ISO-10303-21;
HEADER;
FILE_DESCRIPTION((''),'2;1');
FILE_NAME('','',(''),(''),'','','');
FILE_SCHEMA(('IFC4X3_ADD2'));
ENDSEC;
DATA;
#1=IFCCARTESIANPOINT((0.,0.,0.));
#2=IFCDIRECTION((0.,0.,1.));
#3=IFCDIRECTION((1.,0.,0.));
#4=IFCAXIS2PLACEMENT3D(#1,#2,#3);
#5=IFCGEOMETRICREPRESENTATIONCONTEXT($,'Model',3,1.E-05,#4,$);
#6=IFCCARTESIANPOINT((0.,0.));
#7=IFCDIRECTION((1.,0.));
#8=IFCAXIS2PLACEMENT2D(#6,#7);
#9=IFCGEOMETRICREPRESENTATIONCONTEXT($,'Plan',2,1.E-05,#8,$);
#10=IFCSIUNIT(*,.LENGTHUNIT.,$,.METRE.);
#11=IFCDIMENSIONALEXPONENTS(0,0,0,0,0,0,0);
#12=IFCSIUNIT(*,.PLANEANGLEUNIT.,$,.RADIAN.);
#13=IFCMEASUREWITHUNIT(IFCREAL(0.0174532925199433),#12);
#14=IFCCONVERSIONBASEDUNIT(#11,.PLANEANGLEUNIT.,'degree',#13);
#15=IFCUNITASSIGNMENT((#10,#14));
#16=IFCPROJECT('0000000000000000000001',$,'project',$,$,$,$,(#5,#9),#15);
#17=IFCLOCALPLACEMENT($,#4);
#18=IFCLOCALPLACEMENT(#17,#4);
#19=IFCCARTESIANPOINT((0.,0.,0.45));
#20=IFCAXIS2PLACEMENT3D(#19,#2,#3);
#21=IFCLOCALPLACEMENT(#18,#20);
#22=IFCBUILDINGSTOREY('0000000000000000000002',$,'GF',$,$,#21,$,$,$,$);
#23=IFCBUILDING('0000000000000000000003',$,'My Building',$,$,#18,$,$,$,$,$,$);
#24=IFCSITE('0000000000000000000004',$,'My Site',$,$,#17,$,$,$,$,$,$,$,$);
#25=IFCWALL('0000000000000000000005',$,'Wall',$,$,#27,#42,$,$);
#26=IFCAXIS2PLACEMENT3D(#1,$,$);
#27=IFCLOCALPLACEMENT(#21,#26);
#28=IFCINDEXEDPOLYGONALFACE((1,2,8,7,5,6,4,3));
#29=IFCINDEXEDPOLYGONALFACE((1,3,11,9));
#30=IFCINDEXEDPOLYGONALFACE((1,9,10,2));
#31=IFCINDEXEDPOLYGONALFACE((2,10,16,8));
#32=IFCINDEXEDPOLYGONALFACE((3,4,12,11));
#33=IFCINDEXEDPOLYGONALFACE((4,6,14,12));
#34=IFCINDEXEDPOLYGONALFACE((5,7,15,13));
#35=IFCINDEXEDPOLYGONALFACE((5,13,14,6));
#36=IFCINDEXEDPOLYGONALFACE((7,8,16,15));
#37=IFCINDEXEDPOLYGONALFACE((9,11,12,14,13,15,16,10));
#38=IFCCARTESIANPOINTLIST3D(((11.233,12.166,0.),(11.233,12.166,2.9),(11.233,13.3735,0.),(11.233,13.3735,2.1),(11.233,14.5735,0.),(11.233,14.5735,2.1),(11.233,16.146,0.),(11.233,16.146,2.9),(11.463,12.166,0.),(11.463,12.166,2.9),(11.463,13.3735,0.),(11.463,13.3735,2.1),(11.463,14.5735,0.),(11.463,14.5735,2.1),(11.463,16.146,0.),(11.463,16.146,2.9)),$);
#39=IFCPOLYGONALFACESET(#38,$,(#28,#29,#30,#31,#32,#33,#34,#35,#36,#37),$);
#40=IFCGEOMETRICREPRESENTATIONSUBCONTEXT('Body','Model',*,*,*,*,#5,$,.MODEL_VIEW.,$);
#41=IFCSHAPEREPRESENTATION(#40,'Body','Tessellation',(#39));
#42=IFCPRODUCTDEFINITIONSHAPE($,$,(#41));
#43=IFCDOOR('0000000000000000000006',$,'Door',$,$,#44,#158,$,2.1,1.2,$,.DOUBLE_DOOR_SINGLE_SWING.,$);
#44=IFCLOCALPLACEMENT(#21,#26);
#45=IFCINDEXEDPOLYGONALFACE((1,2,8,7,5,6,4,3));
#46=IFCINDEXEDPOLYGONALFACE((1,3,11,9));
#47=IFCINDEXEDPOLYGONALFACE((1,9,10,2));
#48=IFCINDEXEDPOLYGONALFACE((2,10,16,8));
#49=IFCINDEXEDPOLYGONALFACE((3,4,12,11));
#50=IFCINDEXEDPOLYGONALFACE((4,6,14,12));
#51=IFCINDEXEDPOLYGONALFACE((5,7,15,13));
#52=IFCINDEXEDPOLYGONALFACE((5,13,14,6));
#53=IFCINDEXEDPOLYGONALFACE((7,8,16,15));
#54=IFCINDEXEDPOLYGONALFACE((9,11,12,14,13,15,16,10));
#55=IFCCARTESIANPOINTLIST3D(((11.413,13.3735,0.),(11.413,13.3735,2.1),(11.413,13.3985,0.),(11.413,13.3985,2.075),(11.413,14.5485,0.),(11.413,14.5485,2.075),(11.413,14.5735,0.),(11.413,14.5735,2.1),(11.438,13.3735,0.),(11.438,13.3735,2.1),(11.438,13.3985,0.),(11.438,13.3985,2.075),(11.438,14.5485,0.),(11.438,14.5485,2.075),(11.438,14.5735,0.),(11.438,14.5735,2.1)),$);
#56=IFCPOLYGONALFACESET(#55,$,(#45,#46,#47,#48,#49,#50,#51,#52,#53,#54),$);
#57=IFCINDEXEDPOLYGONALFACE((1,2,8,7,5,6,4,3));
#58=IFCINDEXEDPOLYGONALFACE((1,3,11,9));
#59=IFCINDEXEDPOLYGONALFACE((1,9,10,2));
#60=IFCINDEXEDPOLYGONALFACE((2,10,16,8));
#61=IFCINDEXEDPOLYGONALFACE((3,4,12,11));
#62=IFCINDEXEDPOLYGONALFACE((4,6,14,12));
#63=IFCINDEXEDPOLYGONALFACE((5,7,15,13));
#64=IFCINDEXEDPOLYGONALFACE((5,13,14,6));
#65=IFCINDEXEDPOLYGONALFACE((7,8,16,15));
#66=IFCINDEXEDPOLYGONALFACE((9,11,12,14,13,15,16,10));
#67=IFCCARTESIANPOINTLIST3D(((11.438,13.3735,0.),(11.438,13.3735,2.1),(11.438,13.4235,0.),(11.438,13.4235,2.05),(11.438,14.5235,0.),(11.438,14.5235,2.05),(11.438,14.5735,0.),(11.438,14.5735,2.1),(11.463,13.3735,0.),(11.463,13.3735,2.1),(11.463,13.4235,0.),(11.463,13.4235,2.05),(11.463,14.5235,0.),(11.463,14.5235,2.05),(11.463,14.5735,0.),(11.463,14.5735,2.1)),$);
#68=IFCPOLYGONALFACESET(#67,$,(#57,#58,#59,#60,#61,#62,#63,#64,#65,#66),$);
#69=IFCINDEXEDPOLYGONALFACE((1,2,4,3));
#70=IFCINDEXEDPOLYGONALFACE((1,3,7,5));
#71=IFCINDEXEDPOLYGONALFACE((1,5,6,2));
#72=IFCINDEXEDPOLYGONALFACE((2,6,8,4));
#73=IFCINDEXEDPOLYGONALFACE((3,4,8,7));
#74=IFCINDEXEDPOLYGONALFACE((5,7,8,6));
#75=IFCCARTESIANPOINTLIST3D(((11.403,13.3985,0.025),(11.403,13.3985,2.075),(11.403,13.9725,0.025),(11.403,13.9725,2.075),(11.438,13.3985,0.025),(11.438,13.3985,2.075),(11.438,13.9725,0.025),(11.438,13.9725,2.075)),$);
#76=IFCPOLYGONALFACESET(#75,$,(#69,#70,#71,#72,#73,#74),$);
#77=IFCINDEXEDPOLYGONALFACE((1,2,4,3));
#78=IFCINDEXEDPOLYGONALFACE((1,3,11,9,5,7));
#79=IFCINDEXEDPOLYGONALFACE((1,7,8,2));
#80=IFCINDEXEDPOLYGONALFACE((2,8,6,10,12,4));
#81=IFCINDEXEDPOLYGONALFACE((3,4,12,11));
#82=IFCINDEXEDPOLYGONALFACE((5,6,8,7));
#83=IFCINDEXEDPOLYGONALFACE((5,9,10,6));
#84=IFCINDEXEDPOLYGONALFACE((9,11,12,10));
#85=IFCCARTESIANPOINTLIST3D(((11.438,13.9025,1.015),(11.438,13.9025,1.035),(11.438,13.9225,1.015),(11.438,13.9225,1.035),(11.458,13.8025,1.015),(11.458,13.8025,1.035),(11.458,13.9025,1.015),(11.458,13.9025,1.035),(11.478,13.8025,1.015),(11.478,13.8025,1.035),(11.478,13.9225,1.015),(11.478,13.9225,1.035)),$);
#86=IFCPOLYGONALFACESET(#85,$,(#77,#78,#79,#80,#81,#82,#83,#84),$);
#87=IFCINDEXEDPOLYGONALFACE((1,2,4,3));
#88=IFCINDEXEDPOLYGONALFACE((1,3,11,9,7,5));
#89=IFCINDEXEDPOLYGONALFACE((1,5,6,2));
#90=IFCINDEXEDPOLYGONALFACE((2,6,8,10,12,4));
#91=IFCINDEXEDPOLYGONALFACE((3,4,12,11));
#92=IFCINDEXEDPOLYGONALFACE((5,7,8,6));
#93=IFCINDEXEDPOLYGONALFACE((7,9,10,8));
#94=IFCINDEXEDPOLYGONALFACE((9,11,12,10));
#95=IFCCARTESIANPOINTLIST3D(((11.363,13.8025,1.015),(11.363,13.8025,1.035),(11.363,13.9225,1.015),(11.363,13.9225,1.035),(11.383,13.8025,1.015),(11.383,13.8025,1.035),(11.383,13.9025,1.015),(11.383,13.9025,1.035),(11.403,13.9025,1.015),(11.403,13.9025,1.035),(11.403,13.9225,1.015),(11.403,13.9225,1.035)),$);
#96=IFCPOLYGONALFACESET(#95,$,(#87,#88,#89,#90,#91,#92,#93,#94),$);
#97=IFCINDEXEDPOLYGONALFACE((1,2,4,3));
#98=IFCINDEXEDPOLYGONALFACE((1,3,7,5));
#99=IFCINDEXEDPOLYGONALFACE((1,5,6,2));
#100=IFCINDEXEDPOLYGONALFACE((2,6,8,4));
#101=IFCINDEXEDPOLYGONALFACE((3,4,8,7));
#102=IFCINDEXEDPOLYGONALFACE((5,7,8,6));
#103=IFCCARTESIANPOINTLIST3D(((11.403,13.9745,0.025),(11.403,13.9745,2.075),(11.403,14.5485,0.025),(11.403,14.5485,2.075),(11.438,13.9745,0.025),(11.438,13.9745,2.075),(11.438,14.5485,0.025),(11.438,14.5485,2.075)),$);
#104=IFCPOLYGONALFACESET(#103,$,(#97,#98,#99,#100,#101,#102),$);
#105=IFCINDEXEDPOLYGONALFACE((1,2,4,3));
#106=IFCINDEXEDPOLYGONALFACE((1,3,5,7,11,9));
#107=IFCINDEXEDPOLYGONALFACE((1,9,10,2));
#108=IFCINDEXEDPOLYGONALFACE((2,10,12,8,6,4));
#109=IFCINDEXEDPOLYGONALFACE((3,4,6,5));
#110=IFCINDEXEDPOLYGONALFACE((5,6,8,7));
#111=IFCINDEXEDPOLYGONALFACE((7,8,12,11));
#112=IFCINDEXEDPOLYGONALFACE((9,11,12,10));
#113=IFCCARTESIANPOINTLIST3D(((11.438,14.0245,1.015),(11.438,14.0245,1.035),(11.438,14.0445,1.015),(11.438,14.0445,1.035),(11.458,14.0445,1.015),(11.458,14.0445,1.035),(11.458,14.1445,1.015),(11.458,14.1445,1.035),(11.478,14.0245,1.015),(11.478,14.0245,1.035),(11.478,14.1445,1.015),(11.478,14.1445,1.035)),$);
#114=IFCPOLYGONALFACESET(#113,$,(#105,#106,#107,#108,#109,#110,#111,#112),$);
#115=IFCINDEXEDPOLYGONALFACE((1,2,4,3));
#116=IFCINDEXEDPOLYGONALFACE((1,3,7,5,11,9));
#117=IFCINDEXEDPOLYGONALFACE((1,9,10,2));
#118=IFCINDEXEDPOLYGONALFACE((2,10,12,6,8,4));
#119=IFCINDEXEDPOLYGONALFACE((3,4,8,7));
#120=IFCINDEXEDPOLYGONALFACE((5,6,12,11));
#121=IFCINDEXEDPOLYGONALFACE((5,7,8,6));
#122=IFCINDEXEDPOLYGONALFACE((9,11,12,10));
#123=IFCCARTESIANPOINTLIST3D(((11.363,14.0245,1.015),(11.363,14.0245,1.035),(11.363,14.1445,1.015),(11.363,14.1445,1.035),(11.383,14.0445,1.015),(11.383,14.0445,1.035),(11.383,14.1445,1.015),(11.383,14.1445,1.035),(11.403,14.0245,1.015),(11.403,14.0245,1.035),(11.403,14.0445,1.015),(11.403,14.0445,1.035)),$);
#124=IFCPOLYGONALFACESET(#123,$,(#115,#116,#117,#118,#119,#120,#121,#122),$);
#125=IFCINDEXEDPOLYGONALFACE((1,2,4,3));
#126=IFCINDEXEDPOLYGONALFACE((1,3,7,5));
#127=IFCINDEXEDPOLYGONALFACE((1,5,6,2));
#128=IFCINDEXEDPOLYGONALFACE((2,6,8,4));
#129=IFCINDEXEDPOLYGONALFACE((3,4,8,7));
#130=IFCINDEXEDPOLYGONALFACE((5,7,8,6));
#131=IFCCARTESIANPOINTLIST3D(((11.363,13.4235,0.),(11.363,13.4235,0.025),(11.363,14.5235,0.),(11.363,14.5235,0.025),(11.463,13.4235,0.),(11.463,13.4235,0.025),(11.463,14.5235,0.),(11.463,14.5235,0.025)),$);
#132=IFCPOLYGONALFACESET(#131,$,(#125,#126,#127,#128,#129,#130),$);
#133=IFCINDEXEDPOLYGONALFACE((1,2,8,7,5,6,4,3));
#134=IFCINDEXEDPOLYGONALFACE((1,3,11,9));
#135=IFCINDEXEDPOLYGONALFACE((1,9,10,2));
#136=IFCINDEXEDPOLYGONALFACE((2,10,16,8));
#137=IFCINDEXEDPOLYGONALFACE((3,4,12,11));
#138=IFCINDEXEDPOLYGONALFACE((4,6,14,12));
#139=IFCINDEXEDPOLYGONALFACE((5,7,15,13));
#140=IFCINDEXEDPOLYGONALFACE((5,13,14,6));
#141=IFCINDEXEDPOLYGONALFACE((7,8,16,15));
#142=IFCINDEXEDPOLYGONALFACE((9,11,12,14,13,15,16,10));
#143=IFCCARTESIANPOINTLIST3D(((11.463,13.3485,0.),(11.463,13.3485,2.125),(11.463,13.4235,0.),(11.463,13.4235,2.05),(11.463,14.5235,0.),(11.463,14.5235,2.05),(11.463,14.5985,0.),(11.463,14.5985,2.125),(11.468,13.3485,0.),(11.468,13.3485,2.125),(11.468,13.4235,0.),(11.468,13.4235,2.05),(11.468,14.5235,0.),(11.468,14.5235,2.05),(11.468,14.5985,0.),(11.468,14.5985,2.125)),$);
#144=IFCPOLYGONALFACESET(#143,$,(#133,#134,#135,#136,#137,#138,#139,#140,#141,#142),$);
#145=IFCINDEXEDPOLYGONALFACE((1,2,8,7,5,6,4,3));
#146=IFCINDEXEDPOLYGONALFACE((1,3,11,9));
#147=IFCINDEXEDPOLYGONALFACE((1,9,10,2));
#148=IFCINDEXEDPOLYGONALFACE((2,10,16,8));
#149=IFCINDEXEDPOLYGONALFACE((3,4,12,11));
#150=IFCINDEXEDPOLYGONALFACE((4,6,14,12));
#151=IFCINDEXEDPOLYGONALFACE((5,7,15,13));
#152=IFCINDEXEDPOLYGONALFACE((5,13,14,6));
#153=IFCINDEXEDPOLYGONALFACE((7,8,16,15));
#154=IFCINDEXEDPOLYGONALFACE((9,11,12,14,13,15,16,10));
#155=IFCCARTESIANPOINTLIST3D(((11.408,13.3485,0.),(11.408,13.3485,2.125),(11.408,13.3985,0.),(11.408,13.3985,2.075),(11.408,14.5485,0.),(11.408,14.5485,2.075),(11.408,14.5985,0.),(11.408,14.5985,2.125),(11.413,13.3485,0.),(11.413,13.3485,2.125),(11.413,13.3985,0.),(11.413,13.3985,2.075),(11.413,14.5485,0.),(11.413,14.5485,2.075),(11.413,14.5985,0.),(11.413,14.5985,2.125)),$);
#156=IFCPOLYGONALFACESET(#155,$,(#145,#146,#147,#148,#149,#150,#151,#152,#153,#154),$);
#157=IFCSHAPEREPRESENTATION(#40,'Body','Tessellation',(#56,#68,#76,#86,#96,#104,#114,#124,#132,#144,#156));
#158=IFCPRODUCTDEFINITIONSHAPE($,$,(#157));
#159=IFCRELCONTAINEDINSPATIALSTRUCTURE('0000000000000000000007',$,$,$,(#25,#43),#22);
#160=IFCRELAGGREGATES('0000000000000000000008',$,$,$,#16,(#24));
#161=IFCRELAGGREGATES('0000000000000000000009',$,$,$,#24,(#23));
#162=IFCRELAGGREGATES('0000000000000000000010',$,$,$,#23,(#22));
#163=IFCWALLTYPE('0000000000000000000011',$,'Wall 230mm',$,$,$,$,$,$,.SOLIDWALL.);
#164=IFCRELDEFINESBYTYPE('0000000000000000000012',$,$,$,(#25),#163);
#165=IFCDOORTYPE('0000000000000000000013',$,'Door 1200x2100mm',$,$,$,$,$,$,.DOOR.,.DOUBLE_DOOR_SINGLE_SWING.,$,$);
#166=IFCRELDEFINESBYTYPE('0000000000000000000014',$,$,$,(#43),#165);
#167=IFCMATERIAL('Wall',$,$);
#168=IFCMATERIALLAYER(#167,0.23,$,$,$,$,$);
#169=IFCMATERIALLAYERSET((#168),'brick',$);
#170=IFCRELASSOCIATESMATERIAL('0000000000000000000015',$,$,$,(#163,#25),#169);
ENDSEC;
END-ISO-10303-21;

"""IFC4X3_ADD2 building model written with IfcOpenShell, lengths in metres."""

from ifc_helpers import new_model, entity, si_unit, converted_unit, frame, origin_with_axes, origin_2d_with_axis, place, context, subcontext, project, spatial, line, indexed_curve, outline, extrude, shape, source, transform, mapped, material, layer, layer_set, layer_usage, type_object, type_shapes, element, fill, save


model = new_model("IFC4X3_ADD2")

# Units and contexts
model_context = context("Model", 3, precision=1e-05, world=origin_with_axes())
plan_context = context("Plan", 2, precision=1e-05, world=origin_2d_with_axis())
body_context_1 = subcontext(model_context, "Body", "Model", "MODEL_VIEW")
body_context_2 = subcontext(plan_context, "Body", "Plan", "PLAN_VIEW")
ifc_project = project(units=[si_unit("LENGTHUNIT", "METRE"), converted_unit("PLANEANGLEUNIT", "degree", entity("IfcReal", 0.0174532925199433), si_unit("PLANEANGLEUNIT", "RADIAN"), dimensions=[0, 0, 0, 0, 0, 0, 0])], contexts=[model_context, plan_context])

# Site, building, storey
site_placement = place(None, origin_with_axes())
site = spatial("IfcSite", under=ifc_project, at=site_placement, Name="My Site")
building_placement = place(site_placement, origin_with_axes())
building = spatial("IfcBuilding", under=site, at=building_placement, Name="My Building")
storey_placement = place(building_placement, frame((0.0, 0.0, 0.45), z_axis=(0.0, 0.0, 1.0), x_axis=(1.0, 0.0, 0.0)))
storey = spatial("IfcBuildingStorey", under=building, at=storey_placement, Name="GF")

# Shared definitions
ifc_material_1 = material(Name="Wall")
ifc_layer = layer(ifc_material_1, 0.23)
ifc_layer_set = layer_set([ifc_layer], Name="brick")
wall_type = type_object("IfcWallType", Name="Wall 230mm", PredefinedType="SOLIDWALL", material=ifc_layer_set)

# Wall, opening, door
ifc_layer_usage_1 = layer_usage(ifc_layer_set, "AXIS2", "POSITIVE", 0.0)
wall_1_placement = place(storey_placement, frame((11.463, 12.166, 0.0), z_axis=(0.0, 0.0, 1.0), x_axis=(0.0, 1.0, 0.0)))
wall_1 = element("IfcWall", 1, at=wall_1_placement, inside=storey, type_object=wall_type, material=ifc_layer_usage_1, Name="Wall", context=body_context_1, shape_type="SweptSolid", body=[
    extrude(outline(indexed_curve([(0.0, 0.0), (0.0, 0.23), (3.98, 0.23), (3.98, 0.0), (0.0, 0.0)], self_intersect=False)), origin_with_axes(), (0.0, 0.0, 1.0), 2.9),
])
shared_shape_1 = source(origin_with_axes(), body_context_1, "Body", "SweptSolid", [
    extrude(outline(indexed_curve([(0.0, 0.0), (1.2, 0.0), (1.2, 2.1), (0.0, 2.1)], segments=[line(1, 2, 3, 4, 1)])), frame((0.0, -0.6, 0.0), z_axis=(0.0, -1.0, 0.0), x_axis=(1.0, 0.0, 0.0)), (0.0, 0.0, -1.0), 1.2),
])
opening_1_placement = place(wall_1_placement, frame((1.2075, 0.0, 0.0), z_axis=(0.0, 0.0, 1.0), x_axis=(1.0, 0.0, 0.0)))
opening_1 = element("IfcOpeningElement", 2, at=opening_1_placement, cuts=wall_1, PredefinedType="OPENING", context=body_context_1, shape_type="MappedRepresentation", body=[
    mapped(shared_shape_1, transform((0.0, 0.0, 0.0), x_axis=(1.0, 0.0, 0.0), y_axis=(0.0, 1.0, 0.0), z_axis=(0.0, 0.0, 1.0), scale=1.0)),
])
door_type_1 = type_object("IfcDoorType", Name="Door 1200x2100mm", OperationType="DOUBLE_DOOR_SINGLE_SWING", PredefinedType="DOOR")
shared_shape_2 = source(origin_with_axes(), body_context_1, "Body", "SweptSolid", [
    extrude(outline(indexed_curve([(0.0, 0.0), (0.0, 2.1), (1.2, 2.1), (1.2, 0.0), (1.175, 0.0), (1.175, 2.075), (0.025, 2.075), (0.025, 0.0)], segments=[line(1, 2, 3, 4, 5, 6, 7, 8, 1)])), frame((0.0, 0.025, 0.0), z_axis=(0.0, -1.0, 0.0), x_axis=(1.0, 0.0, 0.0)), (0.0, 0.0, -1.0), 0.025),
    extrude(outline(indexed_curve([(0.0, 0.0), (0.0, 2.1), (1.2, 2.1), (1.2, 0.0), (1.15, 0.0), (1.15, 2.05), (0.05, 2.05), (0.05, 0.0)], segments=[line(1, 2, 3, 4, 5, 6, 7, 8, 1)])), frame((0.0, 0.0, 0.0), z_axis=(0.0, -1.0, 0.0), x_axis=(1.0, 0.0, 0.0)), (0.0, 0.0, -1.0), 0.025),
    extrude(outline(indexed_curve([(0.0, 0.0), (0.574, 0.0), (0.574, 0.035), (0.0, 0.035)], segments=[line(1, 2, 3, 4, 1)])), frame((0.025, 0.025, 0.025), z_axis=(0.0, 0.0, 1.0), x_axis=(1.0, 0.0, 0.0)), (0.0, 0.0, 1.0), 2.05),
    extrude(outline(indexed_curve([(0.0, 0.0), (0.0, -0.04), (-0.12, -0.04), (-0.12, -0.02), (-0.02, -0.02), (-0.02, 0.0)], segments=[line(1, 2, 3, 4, 5, 6, 1)])), frame((0.549, 0.025, 1.015), z_axis=(0.0, 0.0, 1.0), x_axis=(1.0, 0.0, 0.0)), (0.0, 0.0, 1.0), 0.02),
    extrude(outline(indexed_curve([(0.0, 0.0), (0.0, 0.04), (-0.12, 0.04), (-0.12, 0.02), (-0.02, 0.02), (-0.02, 0.0)], segments=[line(1, 2, 3, 4, 5, 6, 1)])), frame((0.549, 0.06, 1.015), z_axis=(0.0, 0.0, 1.0), x_axis=(1.0, 0.0, 0.0)), (0.0, 0.0, 1.0), 0.02),
    extrude(outline(indexed_curve([(0.0, 0.0), (-0.574, 0.0), (-0.574, 0.035), (0.0, 0.035)], segments=[line(1, 2, 3, 4, 1)])), frame((1.175, 0.025, 0.025), z_axis=(0.0, 0.0, 1.0), x_axis=(1.0, 0.0, 0.0)), (0.0, 0.0, 1.0), 2.05),
    extrude(outline(indexed_curve([(0.0, 0.0), (0.0, -0.04), (0.12, -0.04), (0.12, -0.02), (0.02, -0.02), (0.02, 0.0)], segments=[line(1, 2, 3, 4, 5, 6, 1)])), frame((0.651, 0.025, 1.015), z_axis=(0.0, 0.0, 1.0), x_axis=(1.0, 0.0, 0.0)), (0.0, 0.0, 1.0), 0.02),
    extrude(outline(indexed_curve([(0.0, 0.0), (0.0, 0.04), (0.12, 0.04), (0.12, 0.02), (0.02, 0.02), (0.02, 0.0)], segments=[line(1, 2, 3, 4, 5, 6, 1)])), frame((0.651, 0.06, 1.015), z_axis=(0.0, 0.0, 1.0), x_axis=(1.0, 0.0, 0.0)), (0.0, 0.0, 1.0), 0.02),
    extrude(outline(indexed_curve([(0.0, 0.0), (1.1, 0.0), (1.1, 0.1), (0.0, 0.1)], segments=[line(1, 2, 3, 4, 1)])), frame((0.05, 0.0, 0.0), z_axis=(0.0, 0.0, 1.0), x_axis=(1.0, 0.0, 0.0)), (0.0, 0.0, 1.0), 0.025),
    extrude(outline(indexed_curve([(0.0, 0.0), (0.0, 2.125), (1.25, 2.125), (1.25, 0.0), (1.175, 0.0), (1.175, 2.05), (0.075, 2.05), (0.075, 0.0)], segments=[line(1, 2, 3, 4, 5, 6, 7, 8, 1)])), frame((-0.025, -0.005, 0.0), z_axis=(0.0, -1.0, 0.0), x_axis=(1.0, 0.0, 0.0)), (0.0, 0.0, -1.0), 0.005),
    extrude(outline(indexed_curve([(0.0, 0.0), (0.0, 2.125), (1.25, 2.125), (1.25, 0.0), (1.2, 0.0), (1.2, 2.075), (0.05, 2.075), (0.05, 0.0)], segments=[line(1, 2, 3, 4, 5, 6, 7, 8, 1)])), frame((-0.025, 0.05, 0.0), z_axis=(0.0, -1.0, 0.0), x_axis=(1.0, 0.0, 0.0)), (0.0, 0.0, -1.0), 0.005),
])
shared_shape_3 = source(origin_with_axes(), body_context_2, "Body", "Curve2D", [
    entity("IfcIndexedPolyCurve", entity("IfcCartesianPointList2D", [[0.0, 0.0], [0.0, 0.05], [0.025, 0.05], [0.025, 0.025], [0.05, 0.025], [0.05, 0.0]]), [entity("IfcLineIndex", [1, 2, 3, 4, 5, 6, 1])]),
    entity("IfcIndexedPolyCurve", entity("IfcCartesianPointList2D", [[1.2, 0.0], [1.2, 0.05], [1.175, 0.05], [1.175, 0.025], [1.15, 0.025], [1.15, 0.0]]), [entity("IfcLineIndex", [1, 2, 3, 4, 5, 6, 1])]),
    entity("IfcTrimmedCurve", entity("IfcEllipse", entity("IfcAxis2Placement2D", entity("IfcCartesianPoint", [0.06, 0.05]), entity("IfcDirection", [1.0, 0.0])), 0.54, 0.575), [entity("IfcCartesianPoint", [0.6, 0.05])], [entity("IfcCartesianPoint", [0.06, 0.625])], True, "CARTESIAN"),
    entity("IfcIndexedPolyCurve", entity("IfcCartesianPointList2D", [[0.025, 0.05], [0.06, 0.05], [0.06, 0.625], [0.025, 0.625]]), [entity("IfcLineIndex", [1, 2, 3, 4, 1])]),
    entity("IfcTrimmedCurve", entity("IfcEllipse", entity("IfcAxis2Placement2D", entity("IfcCartesianPoint", [1.14, 0.05]), entity("IfcDirection", [1.0, 0.0])), 0.54, 0.575), [entity("IfcCartesianPoint", [1.14, 0.625])], [entity("IfcCartesianPoint", [0.6, 0.05])], True, "CARTESIAN"),
    entity("IfcIndexedPolyCurve", entity("IfcCartesianPointList2D", [[1.175, 0.05], [1.14, 0.05], [1.14, 0.625], [1.175, 0.625]]), [entity("IfcLineIndex", [1, 2, 3, 4, 1])]),
])
type_shapes(door_type_1, [shared_shape_2, shared_shape_3])
door_1_placement = place(opening_1_placement, origin_with_axes())
door_1 = element("IfcDoor", 3, at=door_1_placement, inside=storey, type_object=door_type_1, Name="Door", OperationType="DOUBLE_DOOR_SINGLE_SWING", OverallHeight=2.1, OverallWidth=1.2, shapes=[
    shape(body_context_1, "Body", "MappedRepresentation", [mapped(shared_shape_2, transform((0.0, 0.0, 0.0), x_axis=(1.0, 0.0, 0.0), y_axis=(0.0, 1.0, 0.0), z_axis=(0.0, 0.0, 1.0), scale=1.0))]),
    shape(body_context_2, "Body", "MappedRepresentation", [mapped(shared_shape_3, transform((0.0, 0.0, 0.0), x_axis=(1.0, 0.0, 0.0), y_axis=(0.0, 1.0, 0.0), z_axis=(0.0, 0.0, 1.0), scale=1.0))]),
])
fill(opening_1, door_1)

save(model, "model.ifc")
